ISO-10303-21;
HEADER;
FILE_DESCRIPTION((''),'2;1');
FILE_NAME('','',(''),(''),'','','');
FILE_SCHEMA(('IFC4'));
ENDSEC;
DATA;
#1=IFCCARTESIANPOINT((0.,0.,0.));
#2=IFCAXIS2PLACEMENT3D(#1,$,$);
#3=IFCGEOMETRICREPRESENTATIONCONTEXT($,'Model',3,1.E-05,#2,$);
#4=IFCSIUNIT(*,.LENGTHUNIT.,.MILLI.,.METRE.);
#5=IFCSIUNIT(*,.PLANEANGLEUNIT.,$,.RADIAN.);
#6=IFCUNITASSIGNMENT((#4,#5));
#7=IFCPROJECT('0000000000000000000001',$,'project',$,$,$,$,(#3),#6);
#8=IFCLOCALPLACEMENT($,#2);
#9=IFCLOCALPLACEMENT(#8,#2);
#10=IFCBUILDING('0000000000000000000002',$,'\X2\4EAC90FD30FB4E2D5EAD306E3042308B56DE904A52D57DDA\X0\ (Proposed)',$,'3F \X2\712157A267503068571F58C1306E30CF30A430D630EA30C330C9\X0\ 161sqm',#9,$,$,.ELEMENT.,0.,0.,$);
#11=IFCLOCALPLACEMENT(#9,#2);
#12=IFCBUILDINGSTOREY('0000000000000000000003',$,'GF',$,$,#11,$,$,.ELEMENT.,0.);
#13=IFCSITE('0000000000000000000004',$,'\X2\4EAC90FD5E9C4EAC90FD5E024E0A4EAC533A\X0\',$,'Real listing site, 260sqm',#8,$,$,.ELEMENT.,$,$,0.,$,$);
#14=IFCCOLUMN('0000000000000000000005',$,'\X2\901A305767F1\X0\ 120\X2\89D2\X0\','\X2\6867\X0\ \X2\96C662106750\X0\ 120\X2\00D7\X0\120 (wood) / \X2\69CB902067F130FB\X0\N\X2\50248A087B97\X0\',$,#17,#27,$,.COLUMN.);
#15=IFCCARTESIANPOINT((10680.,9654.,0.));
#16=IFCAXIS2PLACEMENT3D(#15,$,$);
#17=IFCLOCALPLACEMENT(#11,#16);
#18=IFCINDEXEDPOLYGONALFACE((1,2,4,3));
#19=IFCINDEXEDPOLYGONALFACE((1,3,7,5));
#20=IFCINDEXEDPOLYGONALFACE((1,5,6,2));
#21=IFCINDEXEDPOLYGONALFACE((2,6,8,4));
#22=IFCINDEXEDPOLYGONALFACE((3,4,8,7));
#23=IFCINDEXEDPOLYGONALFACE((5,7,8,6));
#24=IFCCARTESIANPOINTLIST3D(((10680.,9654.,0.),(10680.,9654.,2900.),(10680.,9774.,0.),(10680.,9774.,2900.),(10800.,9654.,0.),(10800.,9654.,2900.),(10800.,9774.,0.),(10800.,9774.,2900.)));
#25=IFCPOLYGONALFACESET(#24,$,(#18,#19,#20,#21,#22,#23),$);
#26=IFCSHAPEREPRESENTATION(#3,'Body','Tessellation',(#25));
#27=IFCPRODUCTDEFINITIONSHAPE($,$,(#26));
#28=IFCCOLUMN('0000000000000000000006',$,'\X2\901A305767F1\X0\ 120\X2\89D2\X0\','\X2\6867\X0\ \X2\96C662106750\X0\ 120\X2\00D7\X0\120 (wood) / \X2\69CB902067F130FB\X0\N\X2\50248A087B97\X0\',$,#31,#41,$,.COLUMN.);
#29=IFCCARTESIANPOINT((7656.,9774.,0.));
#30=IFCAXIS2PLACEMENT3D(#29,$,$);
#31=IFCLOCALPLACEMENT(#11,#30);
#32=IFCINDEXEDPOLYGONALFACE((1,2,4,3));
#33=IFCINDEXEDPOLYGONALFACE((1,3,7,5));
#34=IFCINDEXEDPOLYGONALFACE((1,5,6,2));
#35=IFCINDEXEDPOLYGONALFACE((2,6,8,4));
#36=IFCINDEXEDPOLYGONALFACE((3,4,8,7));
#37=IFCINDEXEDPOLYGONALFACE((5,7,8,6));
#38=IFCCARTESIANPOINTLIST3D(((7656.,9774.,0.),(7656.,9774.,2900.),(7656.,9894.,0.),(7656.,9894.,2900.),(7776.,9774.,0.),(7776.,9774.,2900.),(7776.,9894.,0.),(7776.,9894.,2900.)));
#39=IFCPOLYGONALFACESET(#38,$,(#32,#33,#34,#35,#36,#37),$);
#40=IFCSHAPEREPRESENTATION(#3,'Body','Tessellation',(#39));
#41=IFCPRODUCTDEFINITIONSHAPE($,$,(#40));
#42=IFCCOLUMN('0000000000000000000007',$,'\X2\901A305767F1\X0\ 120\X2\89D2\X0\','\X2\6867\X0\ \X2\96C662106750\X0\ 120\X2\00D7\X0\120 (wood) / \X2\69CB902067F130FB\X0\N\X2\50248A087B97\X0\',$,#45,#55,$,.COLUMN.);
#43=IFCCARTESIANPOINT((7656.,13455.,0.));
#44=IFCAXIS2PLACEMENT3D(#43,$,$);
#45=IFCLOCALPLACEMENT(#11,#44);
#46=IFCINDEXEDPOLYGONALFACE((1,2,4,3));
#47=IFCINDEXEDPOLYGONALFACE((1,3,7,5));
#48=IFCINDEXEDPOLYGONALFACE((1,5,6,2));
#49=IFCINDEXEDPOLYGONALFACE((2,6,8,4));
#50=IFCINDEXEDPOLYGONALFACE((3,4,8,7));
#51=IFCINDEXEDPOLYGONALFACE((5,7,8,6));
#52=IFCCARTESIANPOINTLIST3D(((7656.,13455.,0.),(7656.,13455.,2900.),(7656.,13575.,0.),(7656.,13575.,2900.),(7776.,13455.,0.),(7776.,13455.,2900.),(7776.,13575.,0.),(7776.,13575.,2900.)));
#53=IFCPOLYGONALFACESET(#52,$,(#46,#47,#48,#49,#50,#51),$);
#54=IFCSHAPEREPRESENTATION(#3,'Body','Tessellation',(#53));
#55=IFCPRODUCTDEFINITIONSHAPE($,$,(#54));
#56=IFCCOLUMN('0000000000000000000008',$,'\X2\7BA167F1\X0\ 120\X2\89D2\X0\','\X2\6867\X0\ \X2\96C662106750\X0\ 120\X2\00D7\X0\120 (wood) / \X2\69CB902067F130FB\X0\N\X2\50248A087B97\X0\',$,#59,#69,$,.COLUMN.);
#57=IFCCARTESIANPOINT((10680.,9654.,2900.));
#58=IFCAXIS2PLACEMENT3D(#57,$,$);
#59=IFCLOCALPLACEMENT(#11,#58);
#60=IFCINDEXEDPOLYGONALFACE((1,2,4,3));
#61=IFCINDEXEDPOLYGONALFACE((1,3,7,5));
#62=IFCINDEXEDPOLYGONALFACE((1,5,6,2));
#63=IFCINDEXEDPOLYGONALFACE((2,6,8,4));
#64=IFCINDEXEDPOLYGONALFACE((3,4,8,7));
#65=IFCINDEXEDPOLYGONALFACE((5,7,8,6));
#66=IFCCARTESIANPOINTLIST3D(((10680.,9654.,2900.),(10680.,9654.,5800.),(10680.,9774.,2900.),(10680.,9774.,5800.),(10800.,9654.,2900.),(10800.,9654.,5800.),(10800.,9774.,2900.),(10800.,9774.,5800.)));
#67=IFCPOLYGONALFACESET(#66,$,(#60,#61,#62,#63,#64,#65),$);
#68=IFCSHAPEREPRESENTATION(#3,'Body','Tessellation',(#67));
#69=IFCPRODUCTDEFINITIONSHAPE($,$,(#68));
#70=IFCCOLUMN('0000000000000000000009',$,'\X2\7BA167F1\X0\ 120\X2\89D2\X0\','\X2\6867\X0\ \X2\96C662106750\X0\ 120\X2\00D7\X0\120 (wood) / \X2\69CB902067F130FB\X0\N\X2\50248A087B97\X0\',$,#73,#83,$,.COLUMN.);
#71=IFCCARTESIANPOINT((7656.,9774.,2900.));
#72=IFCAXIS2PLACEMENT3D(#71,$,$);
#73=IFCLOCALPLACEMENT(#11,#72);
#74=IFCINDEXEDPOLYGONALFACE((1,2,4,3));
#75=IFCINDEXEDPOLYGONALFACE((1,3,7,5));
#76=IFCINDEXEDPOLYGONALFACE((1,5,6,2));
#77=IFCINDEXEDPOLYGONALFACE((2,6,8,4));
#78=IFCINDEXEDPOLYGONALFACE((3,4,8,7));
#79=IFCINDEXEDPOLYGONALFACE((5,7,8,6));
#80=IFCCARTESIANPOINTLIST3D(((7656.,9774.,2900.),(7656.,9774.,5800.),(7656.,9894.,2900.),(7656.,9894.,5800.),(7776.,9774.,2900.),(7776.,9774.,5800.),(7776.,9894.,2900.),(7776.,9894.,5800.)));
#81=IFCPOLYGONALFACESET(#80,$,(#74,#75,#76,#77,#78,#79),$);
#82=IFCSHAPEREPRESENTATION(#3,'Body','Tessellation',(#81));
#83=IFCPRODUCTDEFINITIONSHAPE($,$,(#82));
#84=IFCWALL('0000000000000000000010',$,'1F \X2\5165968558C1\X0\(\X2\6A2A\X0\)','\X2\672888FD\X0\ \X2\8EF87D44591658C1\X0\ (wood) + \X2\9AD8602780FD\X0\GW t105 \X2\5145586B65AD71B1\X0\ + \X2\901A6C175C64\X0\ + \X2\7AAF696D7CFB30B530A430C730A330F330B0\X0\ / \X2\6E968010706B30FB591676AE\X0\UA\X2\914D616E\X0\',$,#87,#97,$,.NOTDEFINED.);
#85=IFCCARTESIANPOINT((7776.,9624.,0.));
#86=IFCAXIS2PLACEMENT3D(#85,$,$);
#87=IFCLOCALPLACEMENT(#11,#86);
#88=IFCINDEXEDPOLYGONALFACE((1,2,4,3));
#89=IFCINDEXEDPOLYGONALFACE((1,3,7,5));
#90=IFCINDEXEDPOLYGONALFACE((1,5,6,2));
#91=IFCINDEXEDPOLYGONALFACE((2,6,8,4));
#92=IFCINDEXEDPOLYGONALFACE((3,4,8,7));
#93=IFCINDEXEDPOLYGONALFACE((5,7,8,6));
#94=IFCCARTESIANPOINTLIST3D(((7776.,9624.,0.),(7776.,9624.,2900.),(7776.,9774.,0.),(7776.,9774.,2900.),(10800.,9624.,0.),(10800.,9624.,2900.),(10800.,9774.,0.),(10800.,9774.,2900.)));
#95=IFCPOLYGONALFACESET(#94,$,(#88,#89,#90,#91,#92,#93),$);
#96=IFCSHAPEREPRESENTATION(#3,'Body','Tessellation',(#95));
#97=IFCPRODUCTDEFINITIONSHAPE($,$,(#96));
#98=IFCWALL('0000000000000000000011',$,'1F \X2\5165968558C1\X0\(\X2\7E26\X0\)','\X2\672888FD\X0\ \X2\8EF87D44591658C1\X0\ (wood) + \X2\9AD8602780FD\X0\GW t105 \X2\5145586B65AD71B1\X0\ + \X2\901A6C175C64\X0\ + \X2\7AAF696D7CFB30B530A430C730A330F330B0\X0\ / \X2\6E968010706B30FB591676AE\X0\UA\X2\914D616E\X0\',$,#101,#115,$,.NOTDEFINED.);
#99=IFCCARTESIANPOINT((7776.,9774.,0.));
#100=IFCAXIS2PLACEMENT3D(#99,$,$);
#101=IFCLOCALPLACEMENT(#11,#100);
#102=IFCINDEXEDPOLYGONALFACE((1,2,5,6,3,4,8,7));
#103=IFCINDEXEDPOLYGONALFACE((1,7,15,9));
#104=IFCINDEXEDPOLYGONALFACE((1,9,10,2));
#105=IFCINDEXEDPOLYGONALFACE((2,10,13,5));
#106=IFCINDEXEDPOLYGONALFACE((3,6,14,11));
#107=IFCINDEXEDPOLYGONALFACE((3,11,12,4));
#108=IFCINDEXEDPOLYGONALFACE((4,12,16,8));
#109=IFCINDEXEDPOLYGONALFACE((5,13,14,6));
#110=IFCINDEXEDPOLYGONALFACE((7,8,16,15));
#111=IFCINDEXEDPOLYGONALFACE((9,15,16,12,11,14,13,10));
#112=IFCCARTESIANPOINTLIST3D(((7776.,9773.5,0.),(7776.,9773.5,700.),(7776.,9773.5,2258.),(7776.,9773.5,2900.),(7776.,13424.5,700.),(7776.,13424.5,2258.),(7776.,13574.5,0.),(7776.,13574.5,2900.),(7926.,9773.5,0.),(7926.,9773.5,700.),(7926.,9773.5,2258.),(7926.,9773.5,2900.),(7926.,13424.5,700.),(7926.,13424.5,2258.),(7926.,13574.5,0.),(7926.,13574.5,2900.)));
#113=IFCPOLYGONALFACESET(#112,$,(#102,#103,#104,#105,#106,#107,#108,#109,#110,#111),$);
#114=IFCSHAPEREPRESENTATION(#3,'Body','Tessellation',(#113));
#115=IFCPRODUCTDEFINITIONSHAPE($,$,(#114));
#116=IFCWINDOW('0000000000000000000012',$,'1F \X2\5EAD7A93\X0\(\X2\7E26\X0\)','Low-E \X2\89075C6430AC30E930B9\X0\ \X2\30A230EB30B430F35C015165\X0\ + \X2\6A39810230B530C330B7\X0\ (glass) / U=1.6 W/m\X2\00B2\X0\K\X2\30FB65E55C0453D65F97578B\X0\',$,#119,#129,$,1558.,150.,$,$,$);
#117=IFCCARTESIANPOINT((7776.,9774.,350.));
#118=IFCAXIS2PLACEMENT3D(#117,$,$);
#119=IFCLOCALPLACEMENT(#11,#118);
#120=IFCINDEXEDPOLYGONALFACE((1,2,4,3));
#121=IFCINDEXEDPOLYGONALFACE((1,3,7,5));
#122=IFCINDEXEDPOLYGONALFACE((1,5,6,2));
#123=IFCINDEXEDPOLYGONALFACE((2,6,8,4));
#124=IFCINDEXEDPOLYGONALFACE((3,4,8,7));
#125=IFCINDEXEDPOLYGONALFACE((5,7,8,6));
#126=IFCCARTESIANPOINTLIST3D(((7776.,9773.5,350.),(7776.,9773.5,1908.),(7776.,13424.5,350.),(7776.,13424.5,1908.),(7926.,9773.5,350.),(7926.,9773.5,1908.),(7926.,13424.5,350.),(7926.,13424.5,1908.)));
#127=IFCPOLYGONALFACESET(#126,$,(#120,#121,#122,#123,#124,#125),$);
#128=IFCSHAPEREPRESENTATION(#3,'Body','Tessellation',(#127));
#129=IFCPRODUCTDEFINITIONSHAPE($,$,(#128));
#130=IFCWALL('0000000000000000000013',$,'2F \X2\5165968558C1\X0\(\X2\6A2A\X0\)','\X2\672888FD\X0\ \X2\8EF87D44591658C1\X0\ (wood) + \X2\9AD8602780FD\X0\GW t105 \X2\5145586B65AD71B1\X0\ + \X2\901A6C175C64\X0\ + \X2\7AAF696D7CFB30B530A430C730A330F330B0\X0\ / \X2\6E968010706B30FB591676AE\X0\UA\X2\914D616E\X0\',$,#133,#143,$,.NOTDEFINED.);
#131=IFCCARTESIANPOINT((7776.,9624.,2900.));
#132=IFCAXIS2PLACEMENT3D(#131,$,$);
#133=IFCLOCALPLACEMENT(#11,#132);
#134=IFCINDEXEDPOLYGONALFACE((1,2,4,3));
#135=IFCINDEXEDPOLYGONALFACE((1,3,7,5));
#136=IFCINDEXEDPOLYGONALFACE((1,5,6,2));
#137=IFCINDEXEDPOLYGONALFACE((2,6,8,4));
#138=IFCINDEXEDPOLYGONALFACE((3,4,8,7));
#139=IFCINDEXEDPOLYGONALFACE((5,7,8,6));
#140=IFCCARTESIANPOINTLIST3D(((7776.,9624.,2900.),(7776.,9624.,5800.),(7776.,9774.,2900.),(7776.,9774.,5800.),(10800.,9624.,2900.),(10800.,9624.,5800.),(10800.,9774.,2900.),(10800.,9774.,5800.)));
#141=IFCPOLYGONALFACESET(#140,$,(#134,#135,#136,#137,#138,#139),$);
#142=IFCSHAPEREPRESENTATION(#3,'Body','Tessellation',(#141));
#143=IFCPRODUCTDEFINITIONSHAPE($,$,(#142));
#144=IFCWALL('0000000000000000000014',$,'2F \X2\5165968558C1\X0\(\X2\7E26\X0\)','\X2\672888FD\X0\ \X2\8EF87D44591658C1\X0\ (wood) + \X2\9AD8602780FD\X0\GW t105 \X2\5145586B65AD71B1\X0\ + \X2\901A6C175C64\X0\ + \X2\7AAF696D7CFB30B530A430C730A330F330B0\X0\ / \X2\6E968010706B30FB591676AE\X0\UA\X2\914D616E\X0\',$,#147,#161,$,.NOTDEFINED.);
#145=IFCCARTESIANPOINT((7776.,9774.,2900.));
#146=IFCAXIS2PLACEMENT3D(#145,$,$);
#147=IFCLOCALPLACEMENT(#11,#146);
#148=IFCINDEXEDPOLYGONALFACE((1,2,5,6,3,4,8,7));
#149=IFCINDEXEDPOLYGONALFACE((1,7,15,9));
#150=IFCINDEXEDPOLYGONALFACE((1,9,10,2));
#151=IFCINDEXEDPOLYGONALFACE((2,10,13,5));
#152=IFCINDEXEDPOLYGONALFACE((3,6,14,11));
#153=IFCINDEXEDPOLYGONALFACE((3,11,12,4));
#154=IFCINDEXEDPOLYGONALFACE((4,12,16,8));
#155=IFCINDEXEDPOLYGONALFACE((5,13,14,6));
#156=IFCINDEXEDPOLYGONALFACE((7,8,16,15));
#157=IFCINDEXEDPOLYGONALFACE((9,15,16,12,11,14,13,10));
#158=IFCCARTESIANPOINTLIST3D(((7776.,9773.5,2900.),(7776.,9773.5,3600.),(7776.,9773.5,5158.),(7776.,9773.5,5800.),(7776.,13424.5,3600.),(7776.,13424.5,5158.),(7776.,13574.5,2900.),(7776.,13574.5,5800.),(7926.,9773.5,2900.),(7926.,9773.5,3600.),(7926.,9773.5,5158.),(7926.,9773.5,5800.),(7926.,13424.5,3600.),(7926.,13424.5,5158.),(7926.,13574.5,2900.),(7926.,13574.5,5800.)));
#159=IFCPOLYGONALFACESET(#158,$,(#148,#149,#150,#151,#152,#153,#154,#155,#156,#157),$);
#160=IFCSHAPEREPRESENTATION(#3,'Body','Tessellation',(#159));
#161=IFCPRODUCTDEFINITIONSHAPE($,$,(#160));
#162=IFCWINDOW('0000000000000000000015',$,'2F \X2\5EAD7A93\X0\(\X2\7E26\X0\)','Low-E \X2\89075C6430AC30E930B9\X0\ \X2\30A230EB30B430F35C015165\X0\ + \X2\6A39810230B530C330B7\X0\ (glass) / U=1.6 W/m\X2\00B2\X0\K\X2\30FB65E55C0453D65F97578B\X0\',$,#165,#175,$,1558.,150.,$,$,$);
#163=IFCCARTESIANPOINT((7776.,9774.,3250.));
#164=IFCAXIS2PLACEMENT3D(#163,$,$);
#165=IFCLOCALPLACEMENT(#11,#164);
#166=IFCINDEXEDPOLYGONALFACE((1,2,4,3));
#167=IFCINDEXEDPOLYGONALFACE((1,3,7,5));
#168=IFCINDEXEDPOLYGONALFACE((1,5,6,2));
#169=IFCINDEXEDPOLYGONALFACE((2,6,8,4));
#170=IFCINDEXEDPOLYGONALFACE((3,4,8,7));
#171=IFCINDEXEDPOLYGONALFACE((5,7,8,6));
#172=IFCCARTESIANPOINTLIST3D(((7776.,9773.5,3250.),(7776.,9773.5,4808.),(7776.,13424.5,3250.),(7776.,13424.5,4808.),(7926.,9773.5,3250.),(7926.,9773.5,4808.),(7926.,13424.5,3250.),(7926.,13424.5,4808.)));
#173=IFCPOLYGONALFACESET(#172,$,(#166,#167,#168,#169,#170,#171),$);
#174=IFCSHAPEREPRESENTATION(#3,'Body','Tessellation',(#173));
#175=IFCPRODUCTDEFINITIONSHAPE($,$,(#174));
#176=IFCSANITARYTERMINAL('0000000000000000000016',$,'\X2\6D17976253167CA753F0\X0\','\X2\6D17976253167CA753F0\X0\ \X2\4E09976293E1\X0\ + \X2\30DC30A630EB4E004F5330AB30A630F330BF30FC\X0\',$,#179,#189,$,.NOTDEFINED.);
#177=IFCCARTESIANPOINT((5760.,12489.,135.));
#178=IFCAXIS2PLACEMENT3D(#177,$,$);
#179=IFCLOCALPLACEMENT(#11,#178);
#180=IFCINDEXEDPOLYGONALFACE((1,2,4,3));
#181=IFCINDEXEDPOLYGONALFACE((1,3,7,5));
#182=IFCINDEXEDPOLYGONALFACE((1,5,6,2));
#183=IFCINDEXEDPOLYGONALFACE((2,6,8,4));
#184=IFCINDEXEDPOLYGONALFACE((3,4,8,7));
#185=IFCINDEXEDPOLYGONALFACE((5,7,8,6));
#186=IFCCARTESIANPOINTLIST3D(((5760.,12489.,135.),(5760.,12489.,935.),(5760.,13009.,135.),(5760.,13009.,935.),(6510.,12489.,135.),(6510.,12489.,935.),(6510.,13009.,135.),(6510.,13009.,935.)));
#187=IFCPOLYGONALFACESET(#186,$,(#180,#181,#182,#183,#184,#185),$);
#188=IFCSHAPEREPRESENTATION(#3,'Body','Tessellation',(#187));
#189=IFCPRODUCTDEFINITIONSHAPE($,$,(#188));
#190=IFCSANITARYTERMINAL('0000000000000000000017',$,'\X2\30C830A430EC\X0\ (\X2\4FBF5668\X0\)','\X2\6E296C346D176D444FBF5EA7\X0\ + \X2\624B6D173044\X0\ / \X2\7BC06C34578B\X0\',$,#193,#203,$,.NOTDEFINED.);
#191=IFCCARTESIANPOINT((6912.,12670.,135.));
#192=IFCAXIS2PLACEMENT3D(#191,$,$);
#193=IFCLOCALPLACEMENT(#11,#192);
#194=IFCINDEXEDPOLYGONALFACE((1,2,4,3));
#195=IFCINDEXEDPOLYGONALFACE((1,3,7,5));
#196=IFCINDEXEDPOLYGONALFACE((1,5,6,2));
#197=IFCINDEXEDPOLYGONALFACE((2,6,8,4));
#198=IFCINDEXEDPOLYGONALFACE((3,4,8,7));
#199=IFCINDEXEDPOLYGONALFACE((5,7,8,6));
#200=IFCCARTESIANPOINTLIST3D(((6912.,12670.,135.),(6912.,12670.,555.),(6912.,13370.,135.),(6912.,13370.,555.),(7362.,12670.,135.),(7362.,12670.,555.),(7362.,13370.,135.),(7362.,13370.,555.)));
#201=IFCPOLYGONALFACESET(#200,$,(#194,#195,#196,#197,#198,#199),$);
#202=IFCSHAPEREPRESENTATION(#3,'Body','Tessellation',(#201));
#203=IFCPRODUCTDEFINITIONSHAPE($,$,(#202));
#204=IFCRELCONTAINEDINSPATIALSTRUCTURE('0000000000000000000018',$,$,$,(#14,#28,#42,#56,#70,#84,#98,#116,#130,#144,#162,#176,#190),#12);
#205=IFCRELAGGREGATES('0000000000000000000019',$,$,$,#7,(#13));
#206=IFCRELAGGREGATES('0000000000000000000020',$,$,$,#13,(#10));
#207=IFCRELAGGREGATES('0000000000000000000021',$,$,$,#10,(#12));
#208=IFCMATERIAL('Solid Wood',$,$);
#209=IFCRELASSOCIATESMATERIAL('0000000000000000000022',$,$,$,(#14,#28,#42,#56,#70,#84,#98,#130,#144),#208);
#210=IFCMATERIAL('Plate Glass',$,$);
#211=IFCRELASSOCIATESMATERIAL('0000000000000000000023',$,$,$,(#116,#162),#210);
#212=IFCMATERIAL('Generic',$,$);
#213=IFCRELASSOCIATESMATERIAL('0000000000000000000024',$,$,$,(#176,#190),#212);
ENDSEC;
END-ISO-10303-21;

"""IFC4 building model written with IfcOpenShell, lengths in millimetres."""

from ifc_helpers import new_model, si_unit, frame, frame_2d, origin, place, context, project, spatial, rectangle, extrude, material, element, fill, save


model = new_model("IFC4")

# Units and contexts
model_context = context("Model", 3, precision=1e-05, world=origin())
ifc_project = project(units=[si_unit("LENGTHUNIT", "METRE", prefix="MILLI"), si_unit("PLANEANGLEUNIT", "RADIAN")], contexts=[model_context])

# Site, building, storey
site_placement = place(None, origin())
site = spatial("IfcSite", under=ifc_project, at=site_placement, Name="京都府京都市上京区", ObjectType="Real listing site, 260sqm", CompositionType="ELEMENT", RefElevation=0.0)
building_placement = place(site_placement, origin())
building = spatial("IfcBuilding", under=site, at=building_placement, Name="京都・中庭のある回遊動線 (Proposed)", ObjectType="3F 無垢材と土壁のハイブリッド 161sqm", CompositionType="ELEMENT", ElevationOfRefHeight=0.0, ElevationOfTerrain=0.0)
storey_placement = place(building_placement, origin())
storey = spatial("IfcBuildingStorey", under=building, at=storey_placement, Name="GF", CompositionType="ELEMENT", Elevation=0.0)

# Columns
ifc_material_1 = material(Name="Solid Wood")
column_1_placement = place(storey_placement, frame((10680.0, 9654.0, 0.0)))
element("IfcColumn", 1, at=column_1_placement, inside=storey, material=ifc_material_1, Name="通し柱 120角", Description="桧 集成材 120×120 (wood) / 構造柱・N値計算", PredefinedType="COLUMN", context=model_context, shape_type="SweptSolid", body=[
    extrude(rectangle(XDim=120.0, YDim=120.0, at=frame_2d((60.0, 60.0))), frame((10680.0, 9654.0, 0.0)), (0.0, 0.0, 1.0), 2900.0),
])
column_2_placement = place(storey_placement, frame((7656.0, 9774.0, 0.0)))
element("IfcColumn", 2, at=column_2_placement, inside=storey, material=ifc_material_1, Name="通し柱 120角", Description="桧 集成材 120×120 (wood) / 構造柱・N値計算", PredefinedType="COLUMN", context=model_context, shape_type="SweptSolid", body=[
    extrude(rectangle(XDim=120.0, YDim=120.0, at=frame_2d((60.0, 60.0))), frame((7656.0, 9774.0, 0.0)), (0.0, 0.0, 1.0), 2900.0),
])
column_3_placement = place(storey_placement, frame((7656.0, 13455.0, 0.0)))
element("IfcColumn", 3, at=column_3_placement, inside=storey, material=ifc_material_1, Name="通し柱 120角", Description="桧 集成材 120×120 (wood) / 構造柱・N値計算", PredefinedType="COLUMN", context=model_context, shape_type="SweptSolid", body=[
    extrude(rectangle(XDim=120.0, YDim=120.0, at=frame_2d((60.0, 60.0))), frame((7656.0, 13455.0, 0.0)), (0.0, 0.0, 1.0), 2900.0),
])
column_4_placement = place(storey_placement, frame((10680.0, 9654.0, 2900.0)))
element("IfcColumn", 4, at=column_4_placement, inside=storey, material=ifc_material_1, Name="管柱 120角", Description="桧 集成材 120×120 (wood) / 構造柱・N値計算", PredefinedType="COLUMN", context=model_context, shape_type="SweptSolid", body=[
    extrude(rectangle(XDim=120.0, YDim=120.0, at=frame_2d((60.0, 60.0))), frame((10680.0, 9654.0, 2900.0)), (0.0, 0.0, 1.0), 2900.0),
])
column_5_placement = place(storey_placement, frame((7656.0, 9774.0, 2900.0)))
element("IfcColumn", 5, at=column_5_placement, inside=storey, material=ifc_material_1, Name="管柱 120角", Description="桧 集成材 120×120 (wood) / 構造柱・N値計算", PredefinedType="COLUMN", context=model_context, shape_type="SweptSolid", body=[
    extrude(rectangle(XDim=120.0, YDim=120.0, at=frame_2d((60.0, 60.0))), frame((7656.0, 9774.0, 2900.0)), (0.0, 0.0, 1.0), 2900.0),
])

# Wall
wall_1_placement = place(storey_placement, frame((7776.0, 9624.0, 0.0)))
element("IfcWall", 6, at=wall_1_placement, inside=storey, material=ifc_material_1, Name="1F 入隅壁(横)", Description="木製 軸組外壁 (wood) + 高性能GW t105 充填断熱 + 通気層 + 窯業系サイディング / 準耐火・外皮UA配慮", PredefinedType="NOTDEFINED", context=model_context, shape_type="SweptSolid", body=[
    extrude(rectangle(XDim=3024.0, YDim=150.0, at=frame_2d((1512.0, 75.0))), frame((7776.0, 9624.0, 0.0)), (0.0, 0.0, 1.0), 2900.0),
])

# Wall, opening, window
wall_2_placement = place(storey_placement, frame((7776.0, 9774.0, 0.0)))
wall_2 = element("IfcWall", 7, at=wall_2_placement, inside=storey, material=ifc_material_1, Name="1F 入隅壁(縦)", Description="木製 軸組外壁 (wood) + 高性能GW t105 充填断熱 + 通気層 + 窯業系サイディング / 準耐火・外皮UA配慮", PredefinedType="NOTDEFINED", context=model_context, shape_type="SweptSolid", body=[
    extrude(rectangle(XDim=150.0, YDim=3801.0, at=frame_2d((75.0, 1900.0))), frame((7776.0, 9774.0, 0.0)), (0.0, 0.0, 1.0), 2900.0),
])
opening_1_placement = place(storey_placement, frame((7776.0, 9774.0, 350.0)))
opening_1 = element("IfcOpeningElement", 8, at=opening_1_placement, cuts=wall_2, PredefinedType="NOTDEFINED", context=model_context, shape_type="SweptSolid", body=[
    extrude(rectangle(XDim=150.0, YDim=3651.0, at=frame_2d((75.0, 1825.0))), frame((7776.0, 9774.0, 350.0)), (0.0, 0.0, 1.0), 1558.0),
])
ifc_material_2 = material(Name="Plate Glass")
window_1_placement = place(storey_placement, frame((7776.0, 9774.0, 350.0)))
window_1 = element("IfcWindow", 9, at=window_1_placement, inside=storey, material=ifc_material_2, Name="1F 庭窓(縦)", Description="Low-E 複層ガラス アルゴン封入 + 樹脂サッシ (glass) / U=1.6 W/m²K・日射取得型", OverallHeight=1558.0, OverallWidth=150.0, context=model_context, shape_type="SweptSolid", body=[
    extrude(rectangle(XDim=150.0, YDim=3651.0, at=frame_2d((75.0, 1825.0))), frame((7776.0, 9774.0, 350.0)), (0.0, 0.0, 1.0), 1558.0),
])
fill(opening_1, window_1)

# Wall
wall_3_placement = place(storey_placement, frame((7776.0, 9624.0, 2900.0)))
element("IfcWall", 10, at=wall_3_placement, inside=storey, material=ifc_material_1, Name="2F 入隅壁(横)", Description="木製 軸組外壁 (wood) + 高性能GW t105 充填断熱 + 通気層 + 窯業系サイディング / 準耐火・外皮UA配慮", PredefinedType="NOTDEFINED", context=model_context, shape_type="SweptSolid", body=[
    extrude(rectangle(XDim=3024.0, YDim=150.0, at=frame_2d((1512.0, 75.0))), frame((7776.0, 9624.0, 2900.0)), (0.0, 0.0, 1.0), 2900.0),
])

# Wall, opening, window
wall_4_placement = place(storey_placement, frame((7776.0, 9774.0, 2900.0)))
wall_4 = element("IfcWall", 11, at=wall_4_placement, inside=storey, material=ifc_material_1, Name="2F 入隅壁(縦)", Description="木製 軸組外壁 (wood) + 高性能GW t105 充填断熱 + 通気層 + 窯業系サイディング / 準耐火・外皮UA配慮", PredefinedType="NOTDEFINED", context=model_context, shape_type="SweptSolid", body=[
    extrude(rectangle(XDim=150.0, YDim=3801.0, at=frame_2d((75.0, 1900.0))), frame((7776.0, 9774.0, 2900.0)), (0.0, 0.0, 1.0), 2900.0),
])
opening_2_placement = place(storey_placement, frame((7776.0, 9774.0, 3250.0)))
opening_2 = element("IfcOpeningElement", 12, at=opening_2_placement, cuts=wall_4, PredefinedType="NOTDEFINED", context=model_context, shape_type="SweptSolid", body=[
    extrude(rectangle(XDim=150.0, YDim=3651.0, at=frame_2d((75.0, 1825.0))), frame((7776.0, 9774.0, 3250.0)), (0.0, 0.0, 1.0), 1558.0),
])
window_2_placement = place(storey_placement, frame((7776.0, 9774.0, 3250.0)))
window_2 = element("IfcWindow", 13, at=window_2_placement, inside=storey, material=ifc_material_2, Name="2F 庭窓(縦)", Description="Low-E 複層ガラス アルゴン封入 + 樹脂サッシ (glass) / U=1.6 W/m²K・日射取得型", OverallHeight=1558.0, OverallWidth=150.0, context=model_context, shape_type="SweptSolid", body=[
    extrude(rectangle(XDim=150.0, YDim=3651.0, at=frame_2d((75.0, 1825.0))), frame((7776.0, 9774.0, 3250.0)), (0.0, 0.0, 1.0), 1558.0),
])
fill(opening_2, window_2)

# Sanitary terminals
ifc_material_3 = material(Name="Generic")
sanitary_terminal_1_placement = place(storey_placement, frame((5760.0, 12489.0, 135.0)))
element("IfcSanitaryTerminal", 14, at=sanitary_terminal_1_placement, inside=storey, material=ifc_material_3, Name="洗面化粧台", Description="洗面化粧台 三面鏡 + ボウル一体カウンター", PredefinedType="NOTDEFINED", context=model_context, shape_type="SweptSolid", body=[
    extrude(rectangle(XDim=750.0, YDim=520.0, at=frame_2d((375.0, 260.0))), frame((5760.0, 12489.0, 135.0)), (0.0, 0.0, 1.0), 800.0),
])
sanitary_terminal_2_placement = place(storey_placement, frame((6912.0, 12670.0, 135.0)))
element("IfcSanitaryTerminal", 15, at=sanitary_terminal_2_placement, inside=storey, material=ifc_material_3, Name="トイレ (便器)", Description="温水洗浄便座 + 手洗い / 節水型", PredefinedType="NOTDEFINED", context=model_context, shape_type="SweptSolid", body=[
    extrude(rectangle(XDim=450.0, YDim=700.0, at=frame_2d((225.0, 350.0))), frame((6912.0, 12670.0, 135.0)), (0.0, 0.0, 1.0), 420.0),
])

save(model, "model.ifc")
